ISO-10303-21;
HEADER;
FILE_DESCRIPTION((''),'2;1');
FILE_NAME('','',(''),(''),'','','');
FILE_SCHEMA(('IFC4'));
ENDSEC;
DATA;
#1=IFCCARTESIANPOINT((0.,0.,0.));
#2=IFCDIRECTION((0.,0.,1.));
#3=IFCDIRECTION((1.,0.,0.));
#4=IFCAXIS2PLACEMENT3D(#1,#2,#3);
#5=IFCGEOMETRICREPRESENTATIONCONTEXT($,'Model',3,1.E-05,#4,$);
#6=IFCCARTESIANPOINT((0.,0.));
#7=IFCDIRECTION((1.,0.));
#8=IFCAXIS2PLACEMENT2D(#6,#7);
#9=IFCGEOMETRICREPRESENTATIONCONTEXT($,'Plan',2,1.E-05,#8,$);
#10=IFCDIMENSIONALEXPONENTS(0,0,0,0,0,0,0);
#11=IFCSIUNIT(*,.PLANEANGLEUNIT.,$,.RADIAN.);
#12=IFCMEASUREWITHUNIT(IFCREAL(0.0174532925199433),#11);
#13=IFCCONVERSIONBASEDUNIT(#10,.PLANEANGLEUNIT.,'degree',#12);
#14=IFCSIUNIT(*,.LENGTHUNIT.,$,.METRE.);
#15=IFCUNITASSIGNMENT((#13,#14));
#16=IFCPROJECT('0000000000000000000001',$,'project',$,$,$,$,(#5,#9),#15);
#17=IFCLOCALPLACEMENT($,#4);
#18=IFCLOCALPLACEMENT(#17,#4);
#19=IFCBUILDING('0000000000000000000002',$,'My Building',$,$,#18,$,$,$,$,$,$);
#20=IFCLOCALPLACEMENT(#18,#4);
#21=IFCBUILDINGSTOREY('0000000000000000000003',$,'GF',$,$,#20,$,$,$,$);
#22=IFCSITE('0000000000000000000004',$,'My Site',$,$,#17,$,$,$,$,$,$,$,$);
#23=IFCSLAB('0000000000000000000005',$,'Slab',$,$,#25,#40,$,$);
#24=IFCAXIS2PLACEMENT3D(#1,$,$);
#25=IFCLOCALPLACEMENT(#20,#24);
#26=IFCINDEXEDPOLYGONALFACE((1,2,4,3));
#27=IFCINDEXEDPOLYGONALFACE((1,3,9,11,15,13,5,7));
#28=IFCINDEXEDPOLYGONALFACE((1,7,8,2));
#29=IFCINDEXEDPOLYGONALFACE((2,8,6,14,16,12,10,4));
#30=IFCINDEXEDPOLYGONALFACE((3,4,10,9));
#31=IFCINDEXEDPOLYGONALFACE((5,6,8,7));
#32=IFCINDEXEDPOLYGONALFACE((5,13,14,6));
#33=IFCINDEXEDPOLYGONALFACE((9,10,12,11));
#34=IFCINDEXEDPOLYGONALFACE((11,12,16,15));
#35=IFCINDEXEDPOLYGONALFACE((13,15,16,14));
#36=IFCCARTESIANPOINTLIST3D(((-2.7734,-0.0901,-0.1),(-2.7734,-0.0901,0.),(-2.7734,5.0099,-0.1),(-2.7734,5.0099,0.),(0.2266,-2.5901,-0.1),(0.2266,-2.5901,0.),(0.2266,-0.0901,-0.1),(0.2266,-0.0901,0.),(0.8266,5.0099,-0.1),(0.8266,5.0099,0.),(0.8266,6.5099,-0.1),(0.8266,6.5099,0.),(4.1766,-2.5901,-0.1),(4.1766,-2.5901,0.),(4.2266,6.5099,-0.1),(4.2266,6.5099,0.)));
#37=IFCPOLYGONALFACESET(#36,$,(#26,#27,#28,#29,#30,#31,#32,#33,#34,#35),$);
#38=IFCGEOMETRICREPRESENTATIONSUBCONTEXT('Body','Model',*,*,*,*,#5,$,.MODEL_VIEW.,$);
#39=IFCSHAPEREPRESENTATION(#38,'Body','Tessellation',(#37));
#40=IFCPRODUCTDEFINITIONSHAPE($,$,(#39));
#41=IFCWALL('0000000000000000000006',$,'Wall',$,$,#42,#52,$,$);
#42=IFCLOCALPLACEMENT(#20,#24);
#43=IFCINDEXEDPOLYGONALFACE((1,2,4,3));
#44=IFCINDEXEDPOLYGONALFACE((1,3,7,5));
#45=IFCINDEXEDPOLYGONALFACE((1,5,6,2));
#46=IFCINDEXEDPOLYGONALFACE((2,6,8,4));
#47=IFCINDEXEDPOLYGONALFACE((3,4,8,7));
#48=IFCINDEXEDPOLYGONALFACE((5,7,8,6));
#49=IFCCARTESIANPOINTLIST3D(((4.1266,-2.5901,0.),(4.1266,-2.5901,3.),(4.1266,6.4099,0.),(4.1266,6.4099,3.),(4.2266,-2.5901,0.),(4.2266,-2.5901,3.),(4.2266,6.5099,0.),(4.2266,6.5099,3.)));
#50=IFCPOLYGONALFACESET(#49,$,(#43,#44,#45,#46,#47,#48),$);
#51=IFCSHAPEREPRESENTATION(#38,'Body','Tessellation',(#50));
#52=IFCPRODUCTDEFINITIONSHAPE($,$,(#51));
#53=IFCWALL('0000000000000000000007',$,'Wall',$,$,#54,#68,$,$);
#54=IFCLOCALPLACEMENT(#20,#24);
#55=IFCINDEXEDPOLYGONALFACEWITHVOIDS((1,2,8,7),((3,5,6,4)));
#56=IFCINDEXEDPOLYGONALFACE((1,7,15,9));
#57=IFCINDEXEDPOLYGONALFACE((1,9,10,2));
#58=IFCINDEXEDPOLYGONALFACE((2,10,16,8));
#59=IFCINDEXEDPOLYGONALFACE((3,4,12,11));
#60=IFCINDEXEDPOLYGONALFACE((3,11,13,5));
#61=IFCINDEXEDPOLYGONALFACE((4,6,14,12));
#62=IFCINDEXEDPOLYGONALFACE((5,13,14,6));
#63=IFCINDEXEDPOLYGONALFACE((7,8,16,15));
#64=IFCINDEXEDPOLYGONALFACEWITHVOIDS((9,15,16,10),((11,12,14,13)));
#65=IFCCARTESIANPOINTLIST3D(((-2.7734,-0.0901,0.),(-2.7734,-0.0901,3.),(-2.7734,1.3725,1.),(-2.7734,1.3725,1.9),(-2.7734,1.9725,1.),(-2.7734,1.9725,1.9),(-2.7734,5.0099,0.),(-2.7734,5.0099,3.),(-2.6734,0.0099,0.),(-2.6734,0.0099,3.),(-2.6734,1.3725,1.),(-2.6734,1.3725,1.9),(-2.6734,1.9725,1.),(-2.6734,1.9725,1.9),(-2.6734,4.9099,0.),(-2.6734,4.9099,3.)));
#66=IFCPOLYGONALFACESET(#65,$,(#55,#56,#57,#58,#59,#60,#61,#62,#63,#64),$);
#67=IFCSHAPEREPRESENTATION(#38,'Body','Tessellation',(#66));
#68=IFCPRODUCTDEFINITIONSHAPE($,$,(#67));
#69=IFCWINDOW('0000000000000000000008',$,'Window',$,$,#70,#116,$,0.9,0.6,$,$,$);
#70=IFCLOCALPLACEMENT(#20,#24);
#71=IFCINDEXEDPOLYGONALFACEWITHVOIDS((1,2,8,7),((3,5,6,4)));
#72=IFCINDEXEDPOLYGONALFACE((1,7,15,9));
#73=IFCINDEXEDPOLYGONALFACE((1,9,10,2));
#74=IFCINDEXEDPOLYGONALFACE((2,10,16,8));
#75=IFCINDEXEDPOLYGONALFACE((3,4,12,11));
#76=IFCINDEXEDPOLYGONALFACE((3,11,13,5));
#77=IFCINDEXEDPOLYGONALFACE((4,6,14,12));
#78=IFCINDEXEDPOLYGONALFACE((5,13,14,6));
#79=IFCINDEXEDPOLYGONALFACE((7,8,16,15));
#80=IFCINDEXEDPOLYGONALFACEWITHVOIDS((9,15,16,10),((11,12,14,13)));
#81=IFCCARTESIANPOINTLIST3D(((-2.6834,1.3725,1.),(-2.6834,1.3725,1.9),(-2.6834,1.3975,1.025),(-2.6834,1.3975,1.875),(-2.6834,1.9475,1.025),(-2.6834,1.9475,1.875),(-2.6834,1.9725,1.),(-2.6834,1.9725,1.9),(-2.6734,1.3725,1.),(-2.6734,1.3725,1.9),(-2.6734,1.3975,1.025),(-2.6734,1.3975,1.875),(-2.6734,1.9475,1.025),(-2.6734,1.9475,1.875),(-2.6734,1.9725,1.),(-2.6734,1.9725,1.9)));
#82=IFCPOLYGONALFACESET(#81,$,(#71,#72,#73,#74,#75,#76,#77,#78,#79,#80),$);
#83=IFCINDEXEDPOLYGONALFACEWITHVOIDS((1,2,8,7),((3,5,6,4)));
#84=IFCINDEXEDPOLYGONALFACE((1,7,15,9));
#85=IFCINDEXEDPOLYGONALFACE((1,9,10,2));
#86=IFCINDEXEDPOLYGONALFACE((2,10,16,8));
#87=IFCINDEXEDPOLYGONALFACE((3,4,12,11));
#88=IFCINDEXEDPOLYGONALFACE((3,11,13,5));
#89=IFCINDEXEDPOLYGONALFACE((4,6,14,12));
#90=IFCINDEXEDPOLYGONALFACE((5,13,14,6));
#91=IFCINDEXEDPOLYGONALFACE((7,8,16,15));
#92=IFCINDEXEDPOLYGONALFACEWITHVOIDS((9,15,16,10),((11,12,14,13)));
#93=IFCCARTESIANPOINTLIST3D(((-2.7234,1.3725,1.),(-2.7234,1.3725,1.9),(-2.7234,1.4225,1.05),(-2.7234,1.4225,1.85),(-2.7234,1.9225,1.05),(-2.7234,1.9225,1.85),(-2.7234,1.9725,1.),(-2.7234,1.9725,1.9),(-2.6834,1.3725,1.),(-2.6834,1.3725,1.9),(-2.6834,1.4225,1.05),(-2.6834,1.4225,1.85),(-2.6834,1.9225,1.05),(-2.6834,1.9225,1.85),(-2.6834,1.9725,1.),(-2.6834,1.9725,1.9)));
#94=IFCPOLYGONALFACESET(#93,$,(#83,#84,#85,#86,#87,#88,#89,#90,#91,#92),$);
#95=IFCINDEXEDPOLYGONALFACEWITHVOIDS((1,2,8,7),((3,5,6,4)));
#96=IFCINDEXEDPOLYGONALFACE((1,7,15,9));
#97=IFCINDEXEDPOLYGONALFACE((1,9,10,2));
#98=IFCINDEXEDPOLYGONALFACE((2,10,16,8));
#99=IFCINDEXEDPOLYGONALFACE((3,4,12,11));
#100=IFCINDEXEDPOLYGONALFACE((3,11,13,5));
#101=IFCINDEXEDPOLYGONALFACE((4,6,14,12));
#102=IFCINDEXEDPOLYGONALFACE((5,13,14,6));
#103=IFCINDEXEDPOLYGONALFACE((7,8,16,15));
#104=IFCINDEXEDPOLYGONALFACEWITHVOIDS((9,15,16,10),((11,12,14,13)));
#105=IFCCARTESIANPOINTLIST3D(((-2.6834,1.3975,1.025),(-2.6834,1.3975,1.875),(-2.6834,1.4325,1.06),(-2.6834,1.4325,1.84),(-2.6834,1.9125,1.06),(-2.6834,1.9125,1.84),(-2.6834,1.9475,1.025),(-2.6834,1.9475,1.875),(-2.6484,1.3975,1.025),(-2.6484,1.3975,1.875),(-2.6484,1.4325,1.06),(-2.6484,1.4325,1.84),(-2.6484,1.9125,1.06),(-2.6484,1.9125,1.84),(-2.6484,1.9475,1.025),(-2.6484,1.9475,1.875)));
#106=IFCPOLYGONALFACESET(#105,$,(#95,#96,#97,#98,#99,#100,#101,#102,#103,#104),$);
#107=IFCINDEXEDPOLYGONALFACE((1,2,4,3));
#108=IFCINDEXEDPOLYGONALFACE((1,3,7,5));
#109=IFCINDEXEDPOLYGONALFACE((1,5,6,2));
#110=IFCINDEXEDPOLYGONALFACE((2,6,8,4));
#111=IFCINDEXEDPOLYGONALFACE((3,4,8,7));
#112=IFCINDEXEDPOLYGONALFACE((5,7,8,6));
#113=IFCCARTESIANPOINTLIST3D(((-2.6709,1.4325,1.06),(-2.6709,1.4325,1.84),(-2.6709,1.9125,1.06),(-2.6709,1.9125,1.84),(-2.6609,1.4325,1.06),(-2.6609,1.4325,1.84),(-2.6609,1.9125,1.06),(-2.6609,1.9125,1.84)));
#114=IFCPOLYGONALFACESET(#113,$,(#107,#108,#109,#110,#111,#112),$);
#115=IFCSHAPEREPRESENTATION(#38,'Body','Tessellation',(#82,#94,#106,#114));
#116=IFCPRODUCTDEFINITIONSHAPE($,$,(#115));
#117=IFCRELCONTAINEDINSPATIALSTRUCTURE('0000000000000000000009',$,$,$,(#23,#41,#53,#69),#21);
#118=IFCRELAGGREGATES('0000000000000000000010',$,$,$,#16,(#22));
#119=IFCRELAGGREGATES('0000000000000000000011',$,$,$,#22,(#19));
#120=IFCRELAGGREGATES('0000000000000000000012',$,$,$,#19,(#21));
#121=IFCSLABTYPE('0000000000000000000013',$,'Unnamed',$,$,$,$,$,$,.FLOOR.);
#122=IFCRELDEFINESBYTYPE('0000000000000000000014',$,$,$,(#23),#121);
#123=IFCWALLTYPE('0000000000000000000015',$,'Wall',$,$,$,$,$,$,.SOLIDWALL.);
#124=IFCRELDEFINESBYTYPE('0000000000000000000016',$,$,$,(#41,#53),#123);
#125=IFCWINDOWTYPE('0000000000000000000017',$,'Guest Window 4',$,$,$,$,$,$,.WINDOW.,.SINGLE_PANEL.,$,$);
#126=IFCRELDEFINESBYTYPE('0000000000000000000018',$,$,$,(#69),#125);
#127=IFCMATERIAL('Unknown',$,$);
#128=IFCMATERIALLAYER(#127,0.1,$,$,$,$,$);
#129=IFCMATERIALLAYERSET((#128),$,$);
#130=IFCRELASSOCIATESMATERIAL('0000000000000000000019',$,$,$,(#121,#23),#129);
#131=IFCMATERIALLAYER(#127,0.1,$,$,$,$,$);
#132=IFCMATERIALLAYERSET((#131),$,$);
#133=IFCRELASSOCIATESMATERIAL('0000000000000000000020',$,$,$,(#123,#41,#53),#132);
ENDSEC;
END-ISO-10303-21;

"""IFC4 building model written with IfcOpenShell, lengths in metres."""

from ifc_helpers import new_model, entity, si_unit, converted_unit, frame, origin_with_axes, origin_2d_with_axis, place, context, subcontext, project, spatial, line, indexed_curve, outline, extrude, shape, source, transform, mapped, material, layer, layer_set, layer_usage, type_object, type_shapes, element, fill, save


model = new_model("IFC4")

# Units and contexts
model_context = context("Model", 3, precision=1e-05, world=origin_with_axes())
plan_context = context("Plan", 2, precision=1e-05, world=origin_2d_with_axis())
body_context_1 = subcontext(model_context, "Body", "Model", "MODEL_VIEW")
body_context_2 = subcontext(plan_context, "Body", "Plan", "PLAN_VIEW")
ifc_project = project(units=[converted_unit("PLANEANGLEUNIT", "degree", entity("IfcReal", 0.0174532925199433), si_unit("PLANEANGLEUNIT", "RADIAN"), dimensions=[0, 0, 0, 0, 0, 0, 0]), si_unit("LENGTHUNIT", "METRE")], contexts=[model_context, plan_context])

# Site, building, storey
site_placement = place(None, origin_with_axes())
site = spatial("IfcSite", under=ifc_project, at=site_placement, Name="My Site")
building_placement = place(site_placement, origin_with_axes())
building = spatial("IfcBuilding", under=site, at=building_placement, Name="My Building")
storey_placement = place(building_placement, origin_with_axes())
storey = spatial("IfcBuildingStorey", under=building, at=storey_placement, Name="GF")

# Slab
ifc_material = material(Name="Unknown")
ifc_layer_1 = layer(ifc_material, 0.1)
ifc_layer_set_1 = layer_set([ifc_layer_1])
ifc_layer_usage_1 = layer_usage(ifc_layer_set_1, "AXIS3", "POSITIVE", -0.1)
slab_type = type_object("IfcSlabType", Name="Unnamed", PredefinedType="FLOOR", material=ifc_layer_set_1)
slab_placement = place(storey_placement, frame((4.2266, 6.5099, 0.0), z_axis=(0.0, 0.0, 1.0), x_axis=(1.0, 0.0, 0.0)))
element("IfcSlab", 1, at=slab_placement, inside=storey, type_object=slab_type, material=ifc_layer_usage_1, Name="Slab", context=body_context_1, shape_type="SweptSolid", body=[
    extrude(outline(indexed_curve([(0.0, 0.0), (-3.4, 0.0), (-3.4, -1.5), (-7.0, -1.5), (-7.0, -6.6), (-4.0, -6.6), (-4.0, -9.1), (-0.05, -9.1), (0.0, 0.0)])), frame((0.0, 0.0, -0.1), z_axis=(0.0, 0.0, 1.0), x_axis=(1.0, 0.0, 0.0)), (0.0, 0.0, 1.0), 0.1),
])

# Shared definitions
ifc_layer_2 = layer(ifc_material, 0.1)
ifc_layer_set_2 = layer_set([ifc_layer_2])
wall_type = type_object("IfcWallType", Name="Wall", PredefinedType="SOLIDWALL", material=ifc_layer_set_2)

# Wall
ifc_layer_usage_2 = layer_usage(ifc_layer_set_2, "AXIS2", "POSITIVE", 0.0)
wall_1_placement = place(storey_placement, frame((4.2266, -2.5901, 0.0), z_axis=(0.0, 0.0, 1.0), x_axis=(0.0, 1.0, 0.0)))
element("IfcWall", 2, at=wall_1_placement, inside=storey, type_object=wall_type, material=ifc_layer_usage_2, Name="Wall", context=body_context_1, shape_type="SweptSolid", body=[
    extrude(outline(indexed_curve([(0.0, 0.0), (0.0, 0.1), (9.0, 0.1), (9.1, 0.0)], segments=[line(1, 2, 3, 4, 1)])), origin_with_axes(), (0.0, 0.0, 1.0), 3.0),
])

# Wall, opening, window
ifc_layer_usage_3 = layer_usage(ifc_layer_set_2, "AXIS2", "POSITIVE", 0.0)
wall_2_placement = place(storey_placement, frame((-2.7734, 5.0099, 0.0), z_axis=(0.0, 0.0, 1.0), x_axis=(0.0, -1.0, 0.0)))
wall_2 = element("IfcWall", 3, at=wall_2_placement, inside=storey, type_object=wall_type, material=ifc_layer_usage_3, Name="Wall", context=body_context_1, shape_type="SweptSolid", body=[
    extrude(outline(indexed_curve([(0.0, 0.0), (0.1, 0.1), (5.0, 0.1), (5.1, 0.0)], segments=[line(1, 2, 3, 4, 1)])), origin_with_axes(), (0.0, 0.0, 1.0), 3.0),
])
shared_shape_1 = source(origin_with_axes(), body_context_1, "Body", "SweptSolid", [
    extrude(outline(indexed_curve([(0.0, 0.0), (0.6, 0.0), (0.6, 0.9), (0.0, 0.9)], segments=[line(1, 2, 3, 4, 1)])), frame((0.0, -0.6, 0.0), z_axis=(0.0, -1.0, 0.0), x_axis=(1.0, 0.0, 0.0)), (0.0, 0.0, -1.0), 1.2),
])
opening_1_placement = place(wall_2_placement, frame((3.0374, 0.0, 1.0), z_axis=(0.0, 0.0, 1.0), x_axis=(1.0, 0.0, 0.0)))
opening_1 = element("IfcOpeningElement", 4, at=opening_1_placement, cuts=wall_2, PredefinedType="OPENING", context=body_context_1, shape_type="MappedRepresentation", body=[
    mapped(shared_shape_1, transform((0.0, 0.0, 0.0), x_axis=(1.0, 0.0, 0.0), y_axis=(0.0, 1.0, 0.0), z_axis=(0.0, 0.0, 1.0), scale=1.0)),
])
window_type_1 = type_object("IfcWindowType", Name="Guest Window 4", PartitioningType="SINGLE_PANEL", PredefinedType="WINDOW")
shared_shape_2 = source(origin_with_axes(), body_context_1, "Body", "SweptSolid", [
    extrude(outline(indexed_curve([(0.0, 0.0), (0.6, 0.0), (0.6, 0.9), (0.0, 0.9)], segments=[line(1, 2, 3, 4, 1)]), holes=[indexed_curve([(0.025, 0.025), (0.575, 0.025), (0.575, 0.875), (0.025, 0.875)], segments=[line(1, 2, 3, 4, 1)])]), frame((0.0, 0.09, 0.0), z_axis=(0.0, -1.0, 0.0), x_axis=(1.0, 0.0, 0.0)), (0.0, 0.0, -1.0), 0.01),
    extrude(outline(indexed_curve([(0.0, 0.0), (0.6, 0.0), (0.6, 0.9), (0.0, 0.9)], segments=[line(1, 2, 3, 4, 1)]), holes=[indexed_curve([(0.05, 0.05), (0.55, 0.05), (0.55, 0.85), (0.05, 0.85)], segments=[line(1, 2, 3, 4, 1)])]), frame((0.0, 0.05, 0.0), z_axis=(0.0, -1.0, 0.0), x_axis=(1.0, 0.0, 0.0)), (0.0, 0.0, -1.0), 0.04),
    extrude(outline(indexed_curve([(0.0, 0.0), (0.55, 0.0), (0.55, 0.85), (0.0, 0.85)], segments=[line(1, 2, 3, 4, 1)]), holes=[indexed_curve([(0.035, 0.035), (0.515, 0.035), (0.515, 0.815), (0.035, 0.815)], segments=[line(1, 2, 3, 4, 1)])]), frame((0.025, 0.09, 0.025), z_axis=(0.0, -1.0, 0.0), x_axis=(1.0, 0.0, 0.0)), (0.0, 0.0, -1.0), 0.035),
    extrude(outline(indexed_curve([(0.035, 0.035), (0.515, 0.035), (0.515, 0.815), (0.035, 0.815)], segments=[line(1, 2, 3, 4, 1)])), frame((0.025, 0.1025, 0.025), z_axis=(0.0, -1.0, 0.0), x_axis=(1.0, 0.0, 0.0)), (0.0, 0.0, -1.0), 0.01),
])
shared_shape_3 = source(origin_with_axes(), body_context_2, "Body", "Curve2D", [
    entity("IfcIndexedPolyCurve", entity("IfcCartesianPointList2D", [[0.05, 0.05], [0.55, 0.05]])),
    entity("IfcIndexedPolyCurve", entity("IfcCartesianPointList2D", [[0.0, 0.1], [0.025, 0.1], [0.025, 0.09], [0.05, 0.09], [0.05, 0.05], [0.0, 0.05]]), [entity("IfcLineIndex", [1, 2, 3, 4, 5, 6, 1])]),
    entity("IfcIndexedPolyCurve", entity("IfcCartesianPointList2D", [[0.6, 0.1], [0.575, 0.1], [0.575, 0.09], [0.55, 0.09], [0.55, 0.05], [0.6, 0.05]]), [entity("IfcLineIndex", [1, 2, 3, 4, 5, 6, 1])]),
    entity("IfcIndexedPolyCurve", entity("IfcCartesianPointList2D", [[0.025, 0.09], [0.06, 0.09], [0.06, 0.125], [0.025, 0.125]]), [entity("IfcLineIndex", [1, 2, 3, 4, 1])]),
    entity("IfcIndexedPolyCurve", entity("IfcCartesianPointList2D", [[0.575, 0.09], [0.54, 0.09], [0.54, 0.125], [0.575, 0.125]]), [entity("IfcLineIndex", [1, 2, 3, 4, 1])]),
    entity("IfcIndexedPolyCurve", entity("IfcCartesianPointList2D", [[0.06, 0.09], [0.54, 0.09]])),
    entity("IfcIndexedPolyCurve", entity("IfcCartesianPointList2D", [[0.06, 0.125], [0.54, 0.125]])),
    entity("IfcIndexedPolyCurve", entity("IfcCartesianPointList2D", [[0.06, 0.1075], [0.54, 0.1075]])),
])
type_shapes(window_type_1, [shared_shape_2, shared_shape_3])
window_1_placement = place(opening_1_placement, frame((0.0, 0.0, 0.0), z_axis=(0.0, 0.0, 1.0), x_axis=(1.0, 0.0, 0.0)))
window_1 = element("IfcWindow", 5, at=window_1_placement, inside=storey, type_object=window_type_1, Name="Window", OverallHeight=0.9, OverallWidth=0.6, shapes=[
    shape(body_context_1, "Body", "MappedRepresentation", [mapped(shared_shape_2, transform((0.0, 0.0, 0.0), x_axis=(1.0, 0.0, 0.0), y_axis=(0.0, 1.0, 0.0), z_axis=(0.0, 0.0, 1.0), scale=1.0))]),
    shape(body_context_2, "Body", "MappedRepresentation", [mapped(shared_shape_3, transform((0.0, 0.0, 0.0), x_axis=(1.0, 0.0, 0.0), y_axis=(0.0, 1.0, 0.0), z_axis=(0.0, 0.0, 1.0), scale=1.0))]),
])
fill(opening_1, window_1)

save(model, "model.ifc")
